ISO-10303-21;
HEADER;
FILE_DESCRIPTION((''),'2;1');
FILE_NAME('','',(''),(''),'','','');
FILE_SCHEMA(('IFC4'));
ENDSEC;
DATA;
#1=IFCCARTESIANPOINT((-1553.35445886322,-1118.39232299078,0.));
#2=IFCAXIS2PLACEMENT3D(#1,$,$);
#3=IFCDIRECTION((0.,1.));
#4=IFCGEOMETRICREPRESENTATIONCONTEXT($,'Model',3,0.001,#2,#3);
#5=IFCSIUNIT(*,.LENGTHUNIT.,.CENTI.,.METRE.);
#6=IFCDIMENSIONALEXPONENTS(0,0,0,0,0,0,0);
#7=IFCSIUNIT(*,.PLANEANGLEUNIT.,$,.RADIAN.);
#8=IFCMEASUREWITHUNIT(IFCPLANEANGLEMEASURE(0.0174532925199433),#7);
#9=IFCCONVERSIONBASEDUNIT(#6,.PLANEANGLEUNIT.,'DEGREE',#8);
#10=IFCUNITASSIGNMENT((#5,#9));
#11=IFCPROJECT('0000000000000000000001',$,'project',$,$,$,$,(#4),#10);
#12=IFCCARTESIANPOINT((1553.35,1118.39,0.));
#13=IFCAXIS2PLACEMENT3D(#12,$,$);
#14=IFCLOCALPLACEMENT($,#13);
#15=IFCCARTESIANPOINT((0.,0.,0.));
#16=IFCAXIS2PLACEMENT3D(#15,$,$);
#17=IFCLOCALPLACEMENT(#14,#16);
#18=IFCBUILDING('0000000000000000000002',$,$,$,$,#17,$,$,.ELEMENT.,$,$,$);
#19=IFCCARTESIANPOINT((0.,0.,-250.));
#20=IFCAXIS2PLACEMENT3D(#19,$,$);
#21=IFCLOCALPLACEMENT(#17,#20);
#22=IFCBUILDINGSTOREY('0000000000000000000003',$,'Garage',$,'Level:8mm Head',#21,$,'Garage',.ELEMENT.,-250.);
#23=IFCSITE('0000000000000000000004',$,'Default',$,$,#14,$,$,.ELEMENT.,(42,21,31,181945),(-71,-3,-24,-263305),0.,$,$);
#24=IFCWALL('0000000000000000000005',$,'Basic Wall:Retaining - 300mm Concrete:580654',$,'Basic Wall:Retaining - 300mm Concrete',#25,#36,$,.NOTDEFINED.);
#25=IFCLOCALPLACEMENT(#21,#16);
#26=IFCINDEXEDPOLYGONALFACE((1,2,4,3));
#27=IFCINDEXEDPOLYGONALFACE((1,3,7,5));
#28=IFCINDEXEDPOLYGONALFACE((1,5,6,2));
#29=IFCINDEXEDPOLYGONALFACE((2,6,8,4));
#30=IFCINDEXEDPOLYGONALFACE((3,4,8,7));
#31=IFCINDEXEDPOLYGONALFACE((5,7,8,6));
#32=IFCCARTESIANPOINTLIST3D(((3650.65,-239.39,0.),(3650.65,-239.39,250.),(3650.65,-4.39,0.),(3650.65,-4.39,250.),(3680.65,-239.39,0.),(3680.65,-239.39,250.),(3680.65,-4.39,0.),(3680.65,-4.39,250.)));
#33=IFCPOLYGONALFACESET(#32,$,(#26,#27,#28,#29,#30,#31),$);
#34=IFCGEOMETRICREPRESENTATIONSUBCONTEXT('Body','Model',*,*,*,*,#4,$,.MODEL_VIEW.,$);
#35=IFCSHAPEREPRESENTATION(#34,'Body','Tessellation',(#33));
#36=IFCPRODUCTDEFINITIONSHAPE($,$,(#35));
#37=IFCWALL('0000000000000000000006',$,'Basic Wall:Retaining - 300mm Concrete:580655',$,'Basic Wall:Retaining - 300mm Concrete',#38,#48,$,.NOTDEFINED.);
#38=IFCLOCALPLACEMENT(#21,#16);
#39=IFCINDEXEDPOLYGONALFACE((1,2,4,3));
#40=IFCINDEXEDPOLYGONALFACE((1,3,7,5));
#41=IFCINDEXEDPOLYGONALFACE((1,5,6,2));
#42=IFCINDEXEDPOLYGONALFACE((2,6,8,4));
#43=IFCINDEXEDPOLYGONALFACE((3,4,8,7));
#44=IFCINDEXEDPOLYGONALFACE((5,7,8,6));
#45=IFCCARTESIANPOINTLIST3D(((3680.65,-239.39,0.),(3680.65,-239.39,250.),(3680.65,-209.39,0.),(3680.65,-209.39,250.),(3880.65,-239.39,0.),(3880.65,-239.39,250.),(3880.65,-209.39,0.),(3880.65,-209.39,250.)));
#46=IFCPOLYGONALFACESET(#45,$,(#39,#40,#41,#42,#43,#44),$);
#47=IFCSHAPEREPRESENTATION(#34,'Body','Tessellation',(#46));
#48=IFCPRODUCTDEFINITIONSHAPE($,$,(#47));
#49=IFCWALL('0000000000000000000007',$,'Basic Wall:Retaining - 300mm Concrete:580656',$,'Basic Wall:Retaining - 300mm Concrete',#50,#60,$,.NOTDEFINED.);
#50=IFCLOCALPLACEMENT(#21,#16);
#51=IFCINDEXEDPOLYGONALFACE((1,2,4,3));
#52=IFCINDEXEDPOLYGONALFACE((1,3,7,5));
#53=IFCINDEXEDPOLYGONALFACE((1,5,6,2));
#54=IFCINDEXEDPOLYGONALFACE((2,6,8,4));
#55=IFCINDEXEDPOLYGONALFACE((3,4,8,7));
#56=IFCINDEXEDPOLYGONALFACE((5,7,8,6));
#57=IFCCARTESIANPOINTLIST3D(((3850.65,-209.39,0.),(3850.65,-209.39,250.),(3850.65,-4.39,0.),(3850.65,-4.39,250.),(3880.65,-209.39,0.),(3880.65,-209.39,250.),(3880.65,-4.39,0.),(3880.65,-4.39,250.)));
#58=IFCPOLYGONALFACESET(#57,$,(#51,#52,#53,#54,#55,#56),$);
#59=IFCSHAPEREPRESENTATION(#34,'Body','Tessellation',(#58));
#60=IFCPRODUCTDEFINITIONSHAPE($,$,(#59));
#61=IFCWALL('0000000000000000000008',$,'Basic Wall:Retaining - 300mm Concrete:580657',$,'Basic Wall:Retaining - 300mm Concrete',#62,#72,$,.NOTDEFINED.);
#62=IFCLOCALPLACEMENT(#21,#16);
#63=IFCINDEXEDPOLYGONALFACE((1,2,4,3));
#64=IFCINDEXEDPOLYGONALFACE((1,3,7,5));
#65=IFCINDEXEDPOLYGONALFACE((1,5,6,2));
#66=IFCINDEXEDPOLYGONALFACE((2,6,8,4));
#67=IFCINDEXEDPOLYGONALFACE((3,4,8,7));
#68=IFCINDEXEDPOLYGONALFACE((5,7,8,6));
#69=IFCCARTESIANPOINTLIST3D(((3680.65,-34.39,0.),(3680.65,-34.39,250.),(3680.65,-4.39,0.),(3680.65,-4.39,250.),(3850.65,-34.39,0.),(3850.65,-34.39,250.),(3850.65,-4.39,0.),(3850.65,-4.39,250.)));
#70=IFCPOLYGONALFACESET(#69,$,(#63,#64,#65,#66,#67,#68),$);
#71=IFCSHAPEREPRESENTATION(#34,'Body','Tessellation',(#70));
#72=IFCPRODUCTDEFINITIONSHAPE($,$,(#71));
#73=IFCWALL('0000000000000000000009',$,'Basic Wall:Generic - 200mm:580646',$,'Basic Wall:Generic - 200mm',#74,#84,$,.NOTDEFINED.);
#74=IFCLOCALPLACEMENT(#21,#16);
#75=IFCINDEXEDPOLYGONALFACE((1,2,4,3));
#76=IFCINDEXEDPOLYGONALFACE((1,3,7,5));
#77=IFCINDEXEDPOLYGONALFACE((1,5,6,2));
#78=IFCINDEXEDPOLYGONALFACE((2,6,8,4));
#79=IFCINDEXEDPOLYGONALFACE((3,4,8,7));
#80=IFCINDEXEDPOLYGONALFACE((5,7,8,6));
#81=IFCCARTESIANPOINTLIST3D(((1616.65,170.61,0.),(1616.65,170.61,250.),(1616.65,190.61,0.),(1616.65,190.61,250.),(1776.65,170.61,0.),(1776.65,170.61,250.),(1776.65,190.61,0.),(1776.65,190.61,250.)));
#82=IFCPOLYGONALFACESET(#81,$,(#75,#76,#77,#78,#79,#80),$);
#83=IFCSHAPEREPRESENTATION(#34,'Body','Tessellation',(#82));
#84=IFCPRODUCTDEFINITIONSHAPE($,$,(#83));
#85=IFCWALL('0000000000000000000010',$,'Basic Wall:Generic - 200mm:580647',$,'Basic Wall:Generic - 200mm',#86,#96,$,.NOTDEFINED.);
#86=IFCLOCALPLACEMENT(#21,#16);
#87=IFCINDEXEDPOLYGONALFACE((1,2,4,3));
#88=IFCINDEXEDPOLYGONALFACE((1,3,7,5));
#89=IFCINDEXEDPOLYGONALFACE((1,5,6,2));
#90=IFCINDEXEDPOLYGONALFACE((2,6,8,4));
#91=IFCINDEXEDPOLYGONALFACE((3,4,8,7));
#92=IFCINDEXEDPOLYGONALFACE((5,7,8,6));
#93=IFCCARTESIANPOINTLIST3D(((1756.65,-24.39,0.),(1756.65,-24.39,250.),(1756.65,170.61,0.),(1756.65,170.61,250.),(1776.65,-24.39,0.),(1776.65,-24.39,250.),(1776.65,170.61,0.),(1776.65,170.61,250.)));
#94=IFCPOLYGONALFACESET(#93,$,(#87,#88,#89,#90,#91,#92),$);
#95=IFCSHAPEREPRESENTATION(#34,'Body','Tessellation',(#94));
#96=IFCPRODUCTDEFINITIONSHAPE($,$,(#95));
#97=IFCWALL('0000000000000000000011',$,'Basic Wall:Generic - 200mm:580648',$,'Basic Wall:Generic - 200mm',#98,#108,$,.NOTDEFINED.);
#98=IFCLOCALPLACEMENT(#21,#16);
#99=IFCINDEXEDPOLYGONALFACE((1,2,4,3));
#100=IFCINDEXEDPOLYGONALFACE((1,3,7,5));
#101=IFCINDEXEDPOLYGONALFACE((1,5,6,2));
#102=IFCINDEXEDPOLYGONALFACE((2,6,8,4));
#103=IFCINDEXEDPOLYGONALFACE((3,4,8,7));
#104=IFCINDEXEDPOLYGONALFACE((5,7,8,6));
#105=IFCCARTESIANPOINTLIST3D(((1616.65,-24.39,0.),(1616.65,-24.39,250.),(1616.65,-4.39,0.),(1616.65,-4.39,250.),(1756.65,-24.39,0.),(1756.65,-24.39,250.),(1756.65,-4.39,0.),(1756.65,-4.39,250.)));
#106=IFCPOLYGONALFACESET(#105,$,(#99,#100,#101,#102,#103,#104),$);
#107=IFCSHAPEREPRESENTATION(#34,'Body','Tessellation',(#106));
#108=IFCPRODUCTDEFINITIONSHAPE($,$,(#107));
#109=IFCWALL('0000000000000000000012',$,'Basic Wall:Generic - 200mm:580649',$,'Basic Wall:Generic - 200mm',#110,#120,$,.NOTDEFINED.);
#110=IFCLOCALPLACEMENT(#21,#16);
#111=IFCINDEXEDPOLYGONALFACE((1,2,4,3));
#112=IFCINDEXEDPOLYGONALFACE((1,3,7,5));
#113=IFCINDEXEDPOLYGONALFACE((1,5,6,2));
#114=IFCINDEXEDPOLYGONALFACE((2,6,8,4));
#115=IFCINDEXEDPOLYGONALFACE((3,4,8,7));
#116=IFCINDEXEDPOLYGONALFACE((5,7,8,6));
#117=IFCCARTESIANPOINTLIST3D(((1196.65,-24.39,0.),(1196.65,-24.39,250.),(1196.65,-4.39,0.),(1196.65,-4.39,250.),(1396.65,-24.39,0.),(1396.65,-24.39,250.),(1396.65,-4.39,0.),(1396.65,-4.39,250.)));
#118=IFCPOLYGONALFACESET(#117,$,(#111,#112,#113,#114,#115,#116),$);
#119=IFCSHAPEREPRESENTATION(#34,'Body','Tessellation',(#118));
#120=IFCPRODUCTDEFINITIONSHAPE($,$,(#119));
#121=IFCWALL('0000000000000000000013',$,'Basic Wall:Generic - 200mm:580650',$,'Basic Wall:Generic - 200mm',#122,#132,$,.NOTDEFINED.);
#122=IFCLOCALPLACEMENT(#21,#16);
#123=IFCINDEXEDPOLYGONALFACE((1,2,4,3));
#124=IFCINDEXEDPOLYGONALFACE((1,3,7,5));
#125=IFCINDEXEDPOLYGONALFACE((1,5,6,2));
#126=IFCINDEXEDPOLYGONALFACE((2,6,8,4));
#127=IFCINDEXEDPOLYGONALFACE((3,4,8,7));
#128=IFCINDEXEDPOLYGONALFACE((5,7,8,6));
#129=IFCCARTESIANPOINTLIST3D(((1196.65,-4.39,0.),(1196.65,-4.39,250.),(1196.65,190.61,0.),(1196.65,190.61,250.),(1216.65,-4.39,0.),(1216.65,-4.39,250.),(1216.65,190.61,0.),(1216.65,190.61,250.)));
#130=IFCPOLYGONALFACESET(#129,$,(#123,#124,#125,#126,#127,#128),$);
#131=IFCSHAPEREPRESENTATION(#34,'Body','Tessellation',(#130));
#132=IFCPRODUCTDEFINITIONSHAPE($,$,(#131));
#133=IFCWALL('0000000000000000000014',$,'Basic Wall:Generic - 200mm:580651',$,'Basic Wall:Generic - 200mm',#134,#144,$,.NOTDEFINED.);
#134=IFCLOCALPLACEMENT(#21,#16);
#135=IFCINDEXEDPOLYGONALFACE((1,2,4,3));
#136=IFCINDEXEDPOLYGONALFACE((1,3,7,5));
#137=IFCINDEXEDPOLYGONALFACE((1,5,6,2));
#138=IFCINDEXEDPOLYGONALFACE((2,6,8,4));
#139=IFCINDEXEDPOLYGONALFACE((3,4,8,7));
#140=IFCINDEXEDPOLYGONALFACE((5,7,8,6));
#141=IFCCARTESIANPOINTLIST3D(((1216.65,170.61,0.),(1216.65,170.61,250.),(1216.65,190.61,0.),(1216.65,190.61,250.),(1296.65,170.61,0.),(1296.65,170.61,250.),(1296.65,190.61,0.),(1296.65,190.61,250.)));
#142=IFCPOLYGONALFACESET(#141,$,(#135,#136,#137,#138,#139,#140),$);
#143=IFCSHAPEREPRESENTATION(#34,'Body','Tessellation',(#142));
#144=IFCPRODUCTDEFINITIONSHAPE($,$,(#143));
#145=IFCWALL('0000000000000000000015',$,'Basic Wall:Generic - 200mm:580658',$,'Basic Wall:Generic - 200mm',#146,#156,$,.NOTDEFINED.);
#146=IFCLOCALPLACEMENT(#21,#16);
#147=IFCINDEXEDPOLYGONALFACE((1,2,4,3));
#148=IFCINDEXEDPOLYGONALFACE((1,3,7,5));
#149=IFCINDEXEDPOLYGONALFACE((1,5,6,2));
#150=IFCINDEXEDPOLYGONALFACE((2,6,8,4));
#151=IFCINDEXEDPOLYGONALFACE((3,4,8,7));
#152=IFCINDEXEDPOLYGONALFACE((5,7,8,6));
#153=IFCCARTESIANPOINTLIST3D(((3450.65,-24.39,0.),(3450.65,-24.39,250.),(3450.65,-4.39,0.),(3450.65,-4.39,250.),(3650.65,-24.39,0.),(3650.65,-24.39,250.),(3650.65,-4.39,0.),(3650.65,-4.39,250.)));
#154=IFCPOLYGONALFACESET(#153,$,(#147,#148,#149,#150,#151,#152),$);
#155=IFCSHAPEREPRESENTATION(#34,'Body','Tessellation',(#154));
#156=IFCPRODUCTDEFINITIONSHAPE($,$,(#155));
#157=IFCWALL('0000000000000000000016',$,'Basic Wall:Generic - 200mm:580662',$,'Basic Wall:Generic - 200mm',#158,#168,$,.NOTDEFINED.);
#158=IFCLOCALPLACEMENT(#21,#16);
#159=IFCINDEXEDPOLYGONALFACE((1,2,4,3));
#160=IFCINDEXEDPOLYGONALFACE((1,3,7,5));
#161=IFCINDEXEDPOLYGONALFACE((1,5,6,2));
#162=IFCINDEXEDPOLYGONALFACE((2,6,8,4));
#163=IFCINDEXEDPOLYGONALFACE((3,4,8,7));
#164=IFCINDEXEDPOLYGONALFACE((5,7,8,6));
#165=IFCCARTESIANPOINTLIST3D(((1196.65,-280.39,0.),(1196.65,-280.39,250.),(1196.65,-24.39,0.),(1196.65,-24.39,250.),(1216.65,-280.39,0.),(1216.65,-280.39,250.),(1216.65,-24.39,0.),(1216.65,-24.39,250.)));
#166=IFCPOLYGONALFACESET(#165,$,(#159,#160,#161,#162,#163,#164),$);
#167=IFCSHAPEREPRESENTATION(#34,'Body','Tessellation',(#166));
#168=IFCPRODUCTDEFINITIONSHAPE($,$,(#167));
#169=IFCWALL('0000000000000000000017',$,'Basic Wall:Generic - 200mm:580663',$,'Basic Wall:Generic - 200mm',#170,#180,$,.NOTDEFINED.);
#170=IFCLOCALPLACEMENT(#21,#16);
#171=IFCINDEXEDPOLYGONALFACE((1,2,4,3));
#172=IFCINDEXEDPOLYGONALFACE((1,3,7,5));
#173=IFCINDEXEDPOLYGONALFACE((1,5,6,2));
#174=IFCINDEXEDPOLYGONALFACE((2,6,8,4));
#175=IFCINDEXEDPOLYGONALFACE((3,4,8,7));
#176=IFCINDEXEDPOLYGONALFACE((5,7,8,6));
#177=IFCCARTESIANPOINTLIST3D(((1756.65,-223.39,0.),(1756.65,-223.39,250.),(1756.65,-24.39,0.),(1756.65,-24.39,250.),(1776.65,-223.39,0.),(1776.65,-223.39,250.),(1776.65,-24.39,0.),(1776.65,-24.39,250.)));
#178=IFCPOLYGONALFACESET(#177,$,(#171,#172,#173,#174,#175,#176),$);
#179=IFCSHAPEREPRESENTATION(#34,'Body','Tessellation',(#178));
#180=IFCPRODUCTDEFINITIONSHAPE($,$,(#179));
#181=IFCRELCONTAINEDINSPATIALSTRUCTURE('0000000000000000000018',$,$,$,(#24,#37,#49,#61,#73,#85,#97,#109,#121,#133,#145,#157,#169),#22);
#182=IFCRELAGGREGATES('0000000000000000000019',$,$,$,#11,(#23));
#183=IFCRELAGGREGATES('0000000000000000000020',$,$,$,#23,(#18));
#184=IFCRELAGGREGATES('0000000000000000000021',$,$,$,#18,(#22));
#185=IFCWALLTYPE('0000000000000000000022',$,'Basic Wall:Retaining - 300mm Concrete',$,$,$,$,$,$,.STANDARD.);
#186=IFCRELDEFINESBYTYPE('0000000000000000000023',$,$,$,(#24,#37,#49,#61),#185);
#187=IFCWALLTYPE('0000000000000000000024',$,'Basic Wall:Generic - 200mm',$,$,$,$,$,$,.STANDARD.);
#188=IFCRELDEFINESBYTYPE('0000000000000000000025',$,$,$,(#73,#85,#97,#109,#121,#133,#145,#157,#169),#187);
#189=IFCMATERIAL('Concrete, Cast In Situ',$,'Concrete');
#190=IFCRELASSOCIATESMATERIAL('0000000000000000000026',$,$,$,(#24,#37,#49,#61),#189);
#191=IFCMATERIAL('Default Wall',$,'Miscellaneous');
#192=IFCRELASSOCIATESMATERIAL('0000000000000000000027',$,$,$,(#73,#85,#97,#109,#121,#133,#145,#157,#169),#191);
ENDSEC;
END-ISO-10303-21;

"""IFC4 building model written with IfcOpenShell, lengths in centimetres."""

from ifc_helpers import new_model, entity, si_unit, converted_unit, direction, frame, origin, place, context, subcontext, project, spatial, indexed_curve, outline, extrude, material, type_object, element, save


model = new_model("IFC4")

# Units and contexts
model_context = context("Model", 3, precision=0.001, world=frame((-1553.35445886322, -1118.39232299078, 0.0)), true_north=direction((0.0, 1.0)))
body_context = subcontext(model_context, "Body", "Model", "MODEL_VIEW")
ifc_project = project(units=[si_unit("LENGTHUNIT", "METRE", prefix="CENTI"), converted_unit("PLANEANGLEUNIT", "DEGREE", entity("IfcPlaneAngleMeasure", 0.0174532925199433), si_unit("PLANEANGLEUNIT", "RADIAN"), dimensions=[0, 0, 0, 0, 0, 0, 0])], contexts=[model_context])

# Site, building, storey
site_placement = place(None, frame((1553.35, 1118.39, 0.0)))
site = spatial("IfcSite", under=ifc_project, at=site_placement, Name="Default", CompositionType="ELEMENT", RefLatitude=(42, 21, 31, 181945), RefLongitude=(-71, -3, -24, -263305), RefElevation=0.0)
building_placement = place(site_placement, origin())
building = spatial("IfcBuilding", under=site, at=building_placement, CompositionType="ELEMENT")
storey_placement = place(building_placement, frame((0.0, 0.0, -250.0)))
storey = spatial("IfcBuildingStorey", under=building, at=storey_placement, Name="Garage", ObjectType="Level:8mm Head", LongName="Garage", CompositionType="ELEMENT", Elevation=-250.0)

# Walls
ifc_material_1 = material(Name="Concrete, Cast In Situ", Category="Concrete")
wall_type_1 = type_object("IfcWallType", Name="Basic Wall:Retaining - 300mm Concrete", PredefinedType="STANDARD")
wall_1_placement = place(storey_placement, frame((3665.65, -4.39, 0.0), z_axis=(0.0, 0.0, 1.0), x_axis=(0.0, -1.0, 0.0)))
element("IfcWall", 1, at=wall_1_placement, inside=storey, type_object=wall_type_1, material=ifc_material_1, Name="Basic Wall:Retaining - 300mm Concrete:580654", ObjectType="Basic Wall:Retaining - 300mm Concrete", PredefinedType="NOTDEFINED", context=body_context, shape_type="SweptSolid", body=[
    extrude(outline(indexed_curve([(235.0, 15.0), (0.0, 15.0), (0.0, -15.0), (235.0, -15.0), (235.0, 15.0)], self_intersect=False)), origin(), (0.0, 0.0, 1.0), 250.0),
])
wall_2_placement = place(storey_placement, frame((3680.65, -224.39, 0.0)))
element("IfcWall", 2, at=wall_2_placement, inside=storey, type_object=wall_type_1, material=ifc_material_1, Name="Basic Wall:Retaining - 300mm Concrete:580655", ObjectType="Basic Wall:Retaining - 300mm Concrete", PredefinedType="NOTDEFINED", context=body_context, shape_type="SweptSolid", body=[
    extrude(outline(indexed_curve([(200.0, 15.0), (0.0, 15.0), (0.0, -15.0), (200.0, -15.0), (200.0, 15.0)], self_intersect=False)), origin(), (0.0, 0.0, 1.0), 250.0),
])
wall_3_placement = place(storey_placement, frame((3865.65, -209.39, 0.0), z_axis=(0.0, 0.0, 1.0), x_axis=(0.0, 1.0, 0.0)))
element("IfcWall", 3, at=wall_3_placement, inside=storey, type_object=wall_type_1, material=ifc_material_1, Name="Basic Wall:Retaining - 300mm Concrete:580656", ObjectType="Basic Wall:Retaining - 300mm Concrete", PredefinedType="NOTDEFINED", context=body_context, shape_type="SweptSolid", body=[
    extrude(outline(indexed_curve([(205.0, 15.0), (0.0, 15.0), (0.0, -15.0), (205.0, -15.0), (205.0, 15.0)], self_intersect=False)), origin(), (0.0, 0.0, 1.0), 250.0),
])
wall_4_placement = place(storey_placement, frame((3850.65, -19.39, 0.0), z_axis=(0.0, 0.0, 1.0), x_axis=(-1.0, 0.0, 0.0)))
element("IfcWall", 4, at=wall_4_placement, inside=storey, type_object=wall_type_1, material=ifc_material_1, Name="Basic Wall:Retaining - 300mm Concrete:580657", ObjectType="Basic Wall:Retaining - 300mm Concrete", PredefinedType="NOTDEFINED", context=body_context, shape_type="SweptSolid", body=[
    extrude(outline(indexed_curve([(170.0, 15.0), (0.0, 15.0), (0.0, -15.0), (170.0, -15.0), (170.0, 15.0)], self_intersect=False)), origin(), (0.0, 0.0, 1.0), 250.0),
])
ifc_material_2 = material(Name="Default Wall", Category="Miscellaneous")
wall_type_2 = type_object("IfcWallType", Name="Basic Wall:Generic - 200mm", PredefinedType="STANDARD")
wall_5_placement = place(storey_placement, frame((1616.65, 180.61, 0.0)))
element("IfcWall", 5, at=wall_5_placement, inside=storey, type_object=wall_type_2, material=ifc_material_2, Name="Basic Wall:Generic - 200mm:580646", ObjectType="Basic Wall:Generic - 200mm", PredefinedType="NOTDEFINED", context=body_context, shape_type="SweptSolid", body=[
    extrude(outline(indexed_curve([(160.0, 10.0), (0.0, 10.0), (0.0, -10.0), (160.0, -10.0), (160.0, 10.0)], self_intersect=False)), origin(), (0.0, 0.0, 1.0), 250.0),
])
wall_6_placement = place(storey_placement, frame((1766.65, 170.61, 0.0), z_axis=(0.0, 0.0, 1.0), x_axis=(0.0, -1.0, 0.0)))
element("IfcWall", 6, at=wall_6_placement, inside=storey, type_object=wall_type_2, material=ifc_material_2, Name="Basic Wall:Generic - 200mm:580647", ObjectType="Basic Wall:Generic - 200mm", PredefinedType="NOTDEFINED", context=body_context, shape_type="SweptSolid", body=[
    extrude(outline(indexed_curve([(195.0, 10.0), (0.0, 10.0), (0.0, -10.0), (195.0, -10.0), (195.0, 10.0)], self_intersect=False)), origin(), (0.0, 0.0, 1.0), 250.0),
])
wall_7_placement = place(storey_placement, frame((1616.65, -14.39, 0.0)))
element("IfcWall", 7, at=wall_7_placement, inside=storey, type_object=wall_type_2, material=ifc_material_2, Name="Basic Wall:Generic - 200mm:580648", ObjectType="Basic Wall:Generic - 200mm", PredefinedType="NOTDEFINED", context=body_context, shape_type="SweptSolid", body=[
    extrude(outline(indexed_curve([(140.0, 10.0), (0.0, 10.0), (0.0, -10.0), (140.0, -10.0), (140.0, 10.0)], self_intersect=False)), origin(), (0.0, 0.0, 1.0), 250.0),
])
wall_8_placement = place(storey_placement, frame((1396.65, -14.39, 0.0), z_axis=(0.0, 0.0, 1.0), x_axis=(-1.0, 0.0, 0.0)))
element("IfcWall", 8, at=wall_8_placement, inside=storey, type_object=wall_type_2, material=ifc_material_2, Name="Basic Wall:Generic - 200mm:580649", ObjectType="Basic Wall:Generic - 200mm", PredefinedType="NOTDEFINED", context=body_context, shape_type="SweptSolid", body=[
    extrude(outline(indexed_curve([(200.0, 10.0), (0.0, 10.0), (0.0, -10.0), (200.0, -10.0), (200.0, 10.0)], self_intersect=False)), origin(), (0.0, 0.0, 1.0), 250.0),
])
wall_9_placement = place(storey_placement, frame((1206.65, -4.39, 0.0), z_axis=(0.0, 0.0, 1.0), x_axis=(0.0, 1.0, 0.0)))
element("IfcWall", 9, at=wall_9_placement, inside=storey, type_object=wall_type_2, material=ifc_material_2, Name="Basic Wall:Generic - 200mm:580650", ObjectType="Basic Wall:Generic - 200mm", PredefinedType="NOTDEFINED", context=body_context, shape_type="SweptSolid", body=[
    extrude(outline(indexed_curve([(195.0, 10.0), (0.0, 10.0), (0.0, -10.0), (195.0, -10.0), (195.0, 10.0)], self_intersect=False)), origin(), (0.0, 0.0, 1.0), 250.0),
])
wall_10_placement = place(storey_placement, frame((1216.65, 180.61, 0.0)))
element("IfcWall", 10, at=wall_10_placement, inside=storey, type_object=wall_type_2, material=ifc_material_2, Name="Basic Wall:Generic - 200mm:580651", ObjectType="Basic Wall:Generic - 200mm", PredefinedType="NOTDEFINED", context=body_context, shape_type="SweptSolid", body=[
    extrude(outline(indexed_curve([(80.0, 10.0), (0.0, 10.0), (0.0, -10.0), (80.0, -10.0), (80.0, 10.0)], self_intersect=False)), origin(), (0.0, 0.0, 1.0), 250.0),
])
wall_11_placement = place(storey_placement, frame((3650.65, -14.39, 0.0), z_axis=(0.0, 0.0, 1.0), x_axis=(-1.0, 0.0, 0.0)))
element("IfcWall", 11, at=wall_11_placement, inside=storey, type_object=wall_type_2, material=ifc_material_2, Name="Basic Wall:Generic - 200mm:580658", ObjectType="Basic Wall:Generic - 200mm", PredefinedType="NOTDEFINED", context=body_context, shape_type="SweptSolid", body=[
    extrude(outline(indexed_curve([(200.0, 10.0), (0.0, 10.0), (0.0, -10.0), (200.0, -10.0), (200.0, 10.0)], self_intersect=False)), origin(), (0.0, 0.0, 1.0), 250.0),
])
wall_12_placement = place(storey_placement, frame((1206.65, -24.39, 0.0), z_axis=(0.0, 0.0, 1.0), x_axis=(0.0, -1.0, 0.0)))
element("IfcWall", 12, at=wall_12_placement, inside=storey, type_object=wall_type_2, material=ifc_material_2, Name="Basic Wall:Generic - 200mm:580662", ObjectType="Basic Wall:Generic - 200mm", PredefinedType="NOTDEFINED", context=body_context, shape_type="SweptSolid", body=[
    extrude(outline(indexed_curve([(256.0, 10.0), (0.0, 10.0), (0.0, -10.0), (256.0, -10.0), (256.0, 10.0)], self_intersect=False)), origin(), (0.0, 0.0, 1.0), 250.0),
])
wall_13_placement = place(storey_placement, frame((1766.65, -24.39, 0.0), z_axis=(0.0, 0.0, 1.0), x_axis=(0.0, -1.0, 0.0)))
element("IfcWall", 13, at=wall_13_placement, inside=storey, type_object=wall_type_2, material=ifc_material_2, Name="Basic Wall:Generic - 200mm:580663", ObjectType="Basic Wall:Generic - 200mm", PredefinedType="NOTDEFINED", context=body_context, shape_type="SweptSolid", body=[
    extrude(outline(indexed_curve([(199.0, 10.0), (0.0, 10.0), (0.0, -10.0), (199.0, -10.0), (199.0, 10.0)], self_intersect=False)), origin(), (0.0, 0.0, 1.0), 250.0),
])

save(model, "model.ifc")
